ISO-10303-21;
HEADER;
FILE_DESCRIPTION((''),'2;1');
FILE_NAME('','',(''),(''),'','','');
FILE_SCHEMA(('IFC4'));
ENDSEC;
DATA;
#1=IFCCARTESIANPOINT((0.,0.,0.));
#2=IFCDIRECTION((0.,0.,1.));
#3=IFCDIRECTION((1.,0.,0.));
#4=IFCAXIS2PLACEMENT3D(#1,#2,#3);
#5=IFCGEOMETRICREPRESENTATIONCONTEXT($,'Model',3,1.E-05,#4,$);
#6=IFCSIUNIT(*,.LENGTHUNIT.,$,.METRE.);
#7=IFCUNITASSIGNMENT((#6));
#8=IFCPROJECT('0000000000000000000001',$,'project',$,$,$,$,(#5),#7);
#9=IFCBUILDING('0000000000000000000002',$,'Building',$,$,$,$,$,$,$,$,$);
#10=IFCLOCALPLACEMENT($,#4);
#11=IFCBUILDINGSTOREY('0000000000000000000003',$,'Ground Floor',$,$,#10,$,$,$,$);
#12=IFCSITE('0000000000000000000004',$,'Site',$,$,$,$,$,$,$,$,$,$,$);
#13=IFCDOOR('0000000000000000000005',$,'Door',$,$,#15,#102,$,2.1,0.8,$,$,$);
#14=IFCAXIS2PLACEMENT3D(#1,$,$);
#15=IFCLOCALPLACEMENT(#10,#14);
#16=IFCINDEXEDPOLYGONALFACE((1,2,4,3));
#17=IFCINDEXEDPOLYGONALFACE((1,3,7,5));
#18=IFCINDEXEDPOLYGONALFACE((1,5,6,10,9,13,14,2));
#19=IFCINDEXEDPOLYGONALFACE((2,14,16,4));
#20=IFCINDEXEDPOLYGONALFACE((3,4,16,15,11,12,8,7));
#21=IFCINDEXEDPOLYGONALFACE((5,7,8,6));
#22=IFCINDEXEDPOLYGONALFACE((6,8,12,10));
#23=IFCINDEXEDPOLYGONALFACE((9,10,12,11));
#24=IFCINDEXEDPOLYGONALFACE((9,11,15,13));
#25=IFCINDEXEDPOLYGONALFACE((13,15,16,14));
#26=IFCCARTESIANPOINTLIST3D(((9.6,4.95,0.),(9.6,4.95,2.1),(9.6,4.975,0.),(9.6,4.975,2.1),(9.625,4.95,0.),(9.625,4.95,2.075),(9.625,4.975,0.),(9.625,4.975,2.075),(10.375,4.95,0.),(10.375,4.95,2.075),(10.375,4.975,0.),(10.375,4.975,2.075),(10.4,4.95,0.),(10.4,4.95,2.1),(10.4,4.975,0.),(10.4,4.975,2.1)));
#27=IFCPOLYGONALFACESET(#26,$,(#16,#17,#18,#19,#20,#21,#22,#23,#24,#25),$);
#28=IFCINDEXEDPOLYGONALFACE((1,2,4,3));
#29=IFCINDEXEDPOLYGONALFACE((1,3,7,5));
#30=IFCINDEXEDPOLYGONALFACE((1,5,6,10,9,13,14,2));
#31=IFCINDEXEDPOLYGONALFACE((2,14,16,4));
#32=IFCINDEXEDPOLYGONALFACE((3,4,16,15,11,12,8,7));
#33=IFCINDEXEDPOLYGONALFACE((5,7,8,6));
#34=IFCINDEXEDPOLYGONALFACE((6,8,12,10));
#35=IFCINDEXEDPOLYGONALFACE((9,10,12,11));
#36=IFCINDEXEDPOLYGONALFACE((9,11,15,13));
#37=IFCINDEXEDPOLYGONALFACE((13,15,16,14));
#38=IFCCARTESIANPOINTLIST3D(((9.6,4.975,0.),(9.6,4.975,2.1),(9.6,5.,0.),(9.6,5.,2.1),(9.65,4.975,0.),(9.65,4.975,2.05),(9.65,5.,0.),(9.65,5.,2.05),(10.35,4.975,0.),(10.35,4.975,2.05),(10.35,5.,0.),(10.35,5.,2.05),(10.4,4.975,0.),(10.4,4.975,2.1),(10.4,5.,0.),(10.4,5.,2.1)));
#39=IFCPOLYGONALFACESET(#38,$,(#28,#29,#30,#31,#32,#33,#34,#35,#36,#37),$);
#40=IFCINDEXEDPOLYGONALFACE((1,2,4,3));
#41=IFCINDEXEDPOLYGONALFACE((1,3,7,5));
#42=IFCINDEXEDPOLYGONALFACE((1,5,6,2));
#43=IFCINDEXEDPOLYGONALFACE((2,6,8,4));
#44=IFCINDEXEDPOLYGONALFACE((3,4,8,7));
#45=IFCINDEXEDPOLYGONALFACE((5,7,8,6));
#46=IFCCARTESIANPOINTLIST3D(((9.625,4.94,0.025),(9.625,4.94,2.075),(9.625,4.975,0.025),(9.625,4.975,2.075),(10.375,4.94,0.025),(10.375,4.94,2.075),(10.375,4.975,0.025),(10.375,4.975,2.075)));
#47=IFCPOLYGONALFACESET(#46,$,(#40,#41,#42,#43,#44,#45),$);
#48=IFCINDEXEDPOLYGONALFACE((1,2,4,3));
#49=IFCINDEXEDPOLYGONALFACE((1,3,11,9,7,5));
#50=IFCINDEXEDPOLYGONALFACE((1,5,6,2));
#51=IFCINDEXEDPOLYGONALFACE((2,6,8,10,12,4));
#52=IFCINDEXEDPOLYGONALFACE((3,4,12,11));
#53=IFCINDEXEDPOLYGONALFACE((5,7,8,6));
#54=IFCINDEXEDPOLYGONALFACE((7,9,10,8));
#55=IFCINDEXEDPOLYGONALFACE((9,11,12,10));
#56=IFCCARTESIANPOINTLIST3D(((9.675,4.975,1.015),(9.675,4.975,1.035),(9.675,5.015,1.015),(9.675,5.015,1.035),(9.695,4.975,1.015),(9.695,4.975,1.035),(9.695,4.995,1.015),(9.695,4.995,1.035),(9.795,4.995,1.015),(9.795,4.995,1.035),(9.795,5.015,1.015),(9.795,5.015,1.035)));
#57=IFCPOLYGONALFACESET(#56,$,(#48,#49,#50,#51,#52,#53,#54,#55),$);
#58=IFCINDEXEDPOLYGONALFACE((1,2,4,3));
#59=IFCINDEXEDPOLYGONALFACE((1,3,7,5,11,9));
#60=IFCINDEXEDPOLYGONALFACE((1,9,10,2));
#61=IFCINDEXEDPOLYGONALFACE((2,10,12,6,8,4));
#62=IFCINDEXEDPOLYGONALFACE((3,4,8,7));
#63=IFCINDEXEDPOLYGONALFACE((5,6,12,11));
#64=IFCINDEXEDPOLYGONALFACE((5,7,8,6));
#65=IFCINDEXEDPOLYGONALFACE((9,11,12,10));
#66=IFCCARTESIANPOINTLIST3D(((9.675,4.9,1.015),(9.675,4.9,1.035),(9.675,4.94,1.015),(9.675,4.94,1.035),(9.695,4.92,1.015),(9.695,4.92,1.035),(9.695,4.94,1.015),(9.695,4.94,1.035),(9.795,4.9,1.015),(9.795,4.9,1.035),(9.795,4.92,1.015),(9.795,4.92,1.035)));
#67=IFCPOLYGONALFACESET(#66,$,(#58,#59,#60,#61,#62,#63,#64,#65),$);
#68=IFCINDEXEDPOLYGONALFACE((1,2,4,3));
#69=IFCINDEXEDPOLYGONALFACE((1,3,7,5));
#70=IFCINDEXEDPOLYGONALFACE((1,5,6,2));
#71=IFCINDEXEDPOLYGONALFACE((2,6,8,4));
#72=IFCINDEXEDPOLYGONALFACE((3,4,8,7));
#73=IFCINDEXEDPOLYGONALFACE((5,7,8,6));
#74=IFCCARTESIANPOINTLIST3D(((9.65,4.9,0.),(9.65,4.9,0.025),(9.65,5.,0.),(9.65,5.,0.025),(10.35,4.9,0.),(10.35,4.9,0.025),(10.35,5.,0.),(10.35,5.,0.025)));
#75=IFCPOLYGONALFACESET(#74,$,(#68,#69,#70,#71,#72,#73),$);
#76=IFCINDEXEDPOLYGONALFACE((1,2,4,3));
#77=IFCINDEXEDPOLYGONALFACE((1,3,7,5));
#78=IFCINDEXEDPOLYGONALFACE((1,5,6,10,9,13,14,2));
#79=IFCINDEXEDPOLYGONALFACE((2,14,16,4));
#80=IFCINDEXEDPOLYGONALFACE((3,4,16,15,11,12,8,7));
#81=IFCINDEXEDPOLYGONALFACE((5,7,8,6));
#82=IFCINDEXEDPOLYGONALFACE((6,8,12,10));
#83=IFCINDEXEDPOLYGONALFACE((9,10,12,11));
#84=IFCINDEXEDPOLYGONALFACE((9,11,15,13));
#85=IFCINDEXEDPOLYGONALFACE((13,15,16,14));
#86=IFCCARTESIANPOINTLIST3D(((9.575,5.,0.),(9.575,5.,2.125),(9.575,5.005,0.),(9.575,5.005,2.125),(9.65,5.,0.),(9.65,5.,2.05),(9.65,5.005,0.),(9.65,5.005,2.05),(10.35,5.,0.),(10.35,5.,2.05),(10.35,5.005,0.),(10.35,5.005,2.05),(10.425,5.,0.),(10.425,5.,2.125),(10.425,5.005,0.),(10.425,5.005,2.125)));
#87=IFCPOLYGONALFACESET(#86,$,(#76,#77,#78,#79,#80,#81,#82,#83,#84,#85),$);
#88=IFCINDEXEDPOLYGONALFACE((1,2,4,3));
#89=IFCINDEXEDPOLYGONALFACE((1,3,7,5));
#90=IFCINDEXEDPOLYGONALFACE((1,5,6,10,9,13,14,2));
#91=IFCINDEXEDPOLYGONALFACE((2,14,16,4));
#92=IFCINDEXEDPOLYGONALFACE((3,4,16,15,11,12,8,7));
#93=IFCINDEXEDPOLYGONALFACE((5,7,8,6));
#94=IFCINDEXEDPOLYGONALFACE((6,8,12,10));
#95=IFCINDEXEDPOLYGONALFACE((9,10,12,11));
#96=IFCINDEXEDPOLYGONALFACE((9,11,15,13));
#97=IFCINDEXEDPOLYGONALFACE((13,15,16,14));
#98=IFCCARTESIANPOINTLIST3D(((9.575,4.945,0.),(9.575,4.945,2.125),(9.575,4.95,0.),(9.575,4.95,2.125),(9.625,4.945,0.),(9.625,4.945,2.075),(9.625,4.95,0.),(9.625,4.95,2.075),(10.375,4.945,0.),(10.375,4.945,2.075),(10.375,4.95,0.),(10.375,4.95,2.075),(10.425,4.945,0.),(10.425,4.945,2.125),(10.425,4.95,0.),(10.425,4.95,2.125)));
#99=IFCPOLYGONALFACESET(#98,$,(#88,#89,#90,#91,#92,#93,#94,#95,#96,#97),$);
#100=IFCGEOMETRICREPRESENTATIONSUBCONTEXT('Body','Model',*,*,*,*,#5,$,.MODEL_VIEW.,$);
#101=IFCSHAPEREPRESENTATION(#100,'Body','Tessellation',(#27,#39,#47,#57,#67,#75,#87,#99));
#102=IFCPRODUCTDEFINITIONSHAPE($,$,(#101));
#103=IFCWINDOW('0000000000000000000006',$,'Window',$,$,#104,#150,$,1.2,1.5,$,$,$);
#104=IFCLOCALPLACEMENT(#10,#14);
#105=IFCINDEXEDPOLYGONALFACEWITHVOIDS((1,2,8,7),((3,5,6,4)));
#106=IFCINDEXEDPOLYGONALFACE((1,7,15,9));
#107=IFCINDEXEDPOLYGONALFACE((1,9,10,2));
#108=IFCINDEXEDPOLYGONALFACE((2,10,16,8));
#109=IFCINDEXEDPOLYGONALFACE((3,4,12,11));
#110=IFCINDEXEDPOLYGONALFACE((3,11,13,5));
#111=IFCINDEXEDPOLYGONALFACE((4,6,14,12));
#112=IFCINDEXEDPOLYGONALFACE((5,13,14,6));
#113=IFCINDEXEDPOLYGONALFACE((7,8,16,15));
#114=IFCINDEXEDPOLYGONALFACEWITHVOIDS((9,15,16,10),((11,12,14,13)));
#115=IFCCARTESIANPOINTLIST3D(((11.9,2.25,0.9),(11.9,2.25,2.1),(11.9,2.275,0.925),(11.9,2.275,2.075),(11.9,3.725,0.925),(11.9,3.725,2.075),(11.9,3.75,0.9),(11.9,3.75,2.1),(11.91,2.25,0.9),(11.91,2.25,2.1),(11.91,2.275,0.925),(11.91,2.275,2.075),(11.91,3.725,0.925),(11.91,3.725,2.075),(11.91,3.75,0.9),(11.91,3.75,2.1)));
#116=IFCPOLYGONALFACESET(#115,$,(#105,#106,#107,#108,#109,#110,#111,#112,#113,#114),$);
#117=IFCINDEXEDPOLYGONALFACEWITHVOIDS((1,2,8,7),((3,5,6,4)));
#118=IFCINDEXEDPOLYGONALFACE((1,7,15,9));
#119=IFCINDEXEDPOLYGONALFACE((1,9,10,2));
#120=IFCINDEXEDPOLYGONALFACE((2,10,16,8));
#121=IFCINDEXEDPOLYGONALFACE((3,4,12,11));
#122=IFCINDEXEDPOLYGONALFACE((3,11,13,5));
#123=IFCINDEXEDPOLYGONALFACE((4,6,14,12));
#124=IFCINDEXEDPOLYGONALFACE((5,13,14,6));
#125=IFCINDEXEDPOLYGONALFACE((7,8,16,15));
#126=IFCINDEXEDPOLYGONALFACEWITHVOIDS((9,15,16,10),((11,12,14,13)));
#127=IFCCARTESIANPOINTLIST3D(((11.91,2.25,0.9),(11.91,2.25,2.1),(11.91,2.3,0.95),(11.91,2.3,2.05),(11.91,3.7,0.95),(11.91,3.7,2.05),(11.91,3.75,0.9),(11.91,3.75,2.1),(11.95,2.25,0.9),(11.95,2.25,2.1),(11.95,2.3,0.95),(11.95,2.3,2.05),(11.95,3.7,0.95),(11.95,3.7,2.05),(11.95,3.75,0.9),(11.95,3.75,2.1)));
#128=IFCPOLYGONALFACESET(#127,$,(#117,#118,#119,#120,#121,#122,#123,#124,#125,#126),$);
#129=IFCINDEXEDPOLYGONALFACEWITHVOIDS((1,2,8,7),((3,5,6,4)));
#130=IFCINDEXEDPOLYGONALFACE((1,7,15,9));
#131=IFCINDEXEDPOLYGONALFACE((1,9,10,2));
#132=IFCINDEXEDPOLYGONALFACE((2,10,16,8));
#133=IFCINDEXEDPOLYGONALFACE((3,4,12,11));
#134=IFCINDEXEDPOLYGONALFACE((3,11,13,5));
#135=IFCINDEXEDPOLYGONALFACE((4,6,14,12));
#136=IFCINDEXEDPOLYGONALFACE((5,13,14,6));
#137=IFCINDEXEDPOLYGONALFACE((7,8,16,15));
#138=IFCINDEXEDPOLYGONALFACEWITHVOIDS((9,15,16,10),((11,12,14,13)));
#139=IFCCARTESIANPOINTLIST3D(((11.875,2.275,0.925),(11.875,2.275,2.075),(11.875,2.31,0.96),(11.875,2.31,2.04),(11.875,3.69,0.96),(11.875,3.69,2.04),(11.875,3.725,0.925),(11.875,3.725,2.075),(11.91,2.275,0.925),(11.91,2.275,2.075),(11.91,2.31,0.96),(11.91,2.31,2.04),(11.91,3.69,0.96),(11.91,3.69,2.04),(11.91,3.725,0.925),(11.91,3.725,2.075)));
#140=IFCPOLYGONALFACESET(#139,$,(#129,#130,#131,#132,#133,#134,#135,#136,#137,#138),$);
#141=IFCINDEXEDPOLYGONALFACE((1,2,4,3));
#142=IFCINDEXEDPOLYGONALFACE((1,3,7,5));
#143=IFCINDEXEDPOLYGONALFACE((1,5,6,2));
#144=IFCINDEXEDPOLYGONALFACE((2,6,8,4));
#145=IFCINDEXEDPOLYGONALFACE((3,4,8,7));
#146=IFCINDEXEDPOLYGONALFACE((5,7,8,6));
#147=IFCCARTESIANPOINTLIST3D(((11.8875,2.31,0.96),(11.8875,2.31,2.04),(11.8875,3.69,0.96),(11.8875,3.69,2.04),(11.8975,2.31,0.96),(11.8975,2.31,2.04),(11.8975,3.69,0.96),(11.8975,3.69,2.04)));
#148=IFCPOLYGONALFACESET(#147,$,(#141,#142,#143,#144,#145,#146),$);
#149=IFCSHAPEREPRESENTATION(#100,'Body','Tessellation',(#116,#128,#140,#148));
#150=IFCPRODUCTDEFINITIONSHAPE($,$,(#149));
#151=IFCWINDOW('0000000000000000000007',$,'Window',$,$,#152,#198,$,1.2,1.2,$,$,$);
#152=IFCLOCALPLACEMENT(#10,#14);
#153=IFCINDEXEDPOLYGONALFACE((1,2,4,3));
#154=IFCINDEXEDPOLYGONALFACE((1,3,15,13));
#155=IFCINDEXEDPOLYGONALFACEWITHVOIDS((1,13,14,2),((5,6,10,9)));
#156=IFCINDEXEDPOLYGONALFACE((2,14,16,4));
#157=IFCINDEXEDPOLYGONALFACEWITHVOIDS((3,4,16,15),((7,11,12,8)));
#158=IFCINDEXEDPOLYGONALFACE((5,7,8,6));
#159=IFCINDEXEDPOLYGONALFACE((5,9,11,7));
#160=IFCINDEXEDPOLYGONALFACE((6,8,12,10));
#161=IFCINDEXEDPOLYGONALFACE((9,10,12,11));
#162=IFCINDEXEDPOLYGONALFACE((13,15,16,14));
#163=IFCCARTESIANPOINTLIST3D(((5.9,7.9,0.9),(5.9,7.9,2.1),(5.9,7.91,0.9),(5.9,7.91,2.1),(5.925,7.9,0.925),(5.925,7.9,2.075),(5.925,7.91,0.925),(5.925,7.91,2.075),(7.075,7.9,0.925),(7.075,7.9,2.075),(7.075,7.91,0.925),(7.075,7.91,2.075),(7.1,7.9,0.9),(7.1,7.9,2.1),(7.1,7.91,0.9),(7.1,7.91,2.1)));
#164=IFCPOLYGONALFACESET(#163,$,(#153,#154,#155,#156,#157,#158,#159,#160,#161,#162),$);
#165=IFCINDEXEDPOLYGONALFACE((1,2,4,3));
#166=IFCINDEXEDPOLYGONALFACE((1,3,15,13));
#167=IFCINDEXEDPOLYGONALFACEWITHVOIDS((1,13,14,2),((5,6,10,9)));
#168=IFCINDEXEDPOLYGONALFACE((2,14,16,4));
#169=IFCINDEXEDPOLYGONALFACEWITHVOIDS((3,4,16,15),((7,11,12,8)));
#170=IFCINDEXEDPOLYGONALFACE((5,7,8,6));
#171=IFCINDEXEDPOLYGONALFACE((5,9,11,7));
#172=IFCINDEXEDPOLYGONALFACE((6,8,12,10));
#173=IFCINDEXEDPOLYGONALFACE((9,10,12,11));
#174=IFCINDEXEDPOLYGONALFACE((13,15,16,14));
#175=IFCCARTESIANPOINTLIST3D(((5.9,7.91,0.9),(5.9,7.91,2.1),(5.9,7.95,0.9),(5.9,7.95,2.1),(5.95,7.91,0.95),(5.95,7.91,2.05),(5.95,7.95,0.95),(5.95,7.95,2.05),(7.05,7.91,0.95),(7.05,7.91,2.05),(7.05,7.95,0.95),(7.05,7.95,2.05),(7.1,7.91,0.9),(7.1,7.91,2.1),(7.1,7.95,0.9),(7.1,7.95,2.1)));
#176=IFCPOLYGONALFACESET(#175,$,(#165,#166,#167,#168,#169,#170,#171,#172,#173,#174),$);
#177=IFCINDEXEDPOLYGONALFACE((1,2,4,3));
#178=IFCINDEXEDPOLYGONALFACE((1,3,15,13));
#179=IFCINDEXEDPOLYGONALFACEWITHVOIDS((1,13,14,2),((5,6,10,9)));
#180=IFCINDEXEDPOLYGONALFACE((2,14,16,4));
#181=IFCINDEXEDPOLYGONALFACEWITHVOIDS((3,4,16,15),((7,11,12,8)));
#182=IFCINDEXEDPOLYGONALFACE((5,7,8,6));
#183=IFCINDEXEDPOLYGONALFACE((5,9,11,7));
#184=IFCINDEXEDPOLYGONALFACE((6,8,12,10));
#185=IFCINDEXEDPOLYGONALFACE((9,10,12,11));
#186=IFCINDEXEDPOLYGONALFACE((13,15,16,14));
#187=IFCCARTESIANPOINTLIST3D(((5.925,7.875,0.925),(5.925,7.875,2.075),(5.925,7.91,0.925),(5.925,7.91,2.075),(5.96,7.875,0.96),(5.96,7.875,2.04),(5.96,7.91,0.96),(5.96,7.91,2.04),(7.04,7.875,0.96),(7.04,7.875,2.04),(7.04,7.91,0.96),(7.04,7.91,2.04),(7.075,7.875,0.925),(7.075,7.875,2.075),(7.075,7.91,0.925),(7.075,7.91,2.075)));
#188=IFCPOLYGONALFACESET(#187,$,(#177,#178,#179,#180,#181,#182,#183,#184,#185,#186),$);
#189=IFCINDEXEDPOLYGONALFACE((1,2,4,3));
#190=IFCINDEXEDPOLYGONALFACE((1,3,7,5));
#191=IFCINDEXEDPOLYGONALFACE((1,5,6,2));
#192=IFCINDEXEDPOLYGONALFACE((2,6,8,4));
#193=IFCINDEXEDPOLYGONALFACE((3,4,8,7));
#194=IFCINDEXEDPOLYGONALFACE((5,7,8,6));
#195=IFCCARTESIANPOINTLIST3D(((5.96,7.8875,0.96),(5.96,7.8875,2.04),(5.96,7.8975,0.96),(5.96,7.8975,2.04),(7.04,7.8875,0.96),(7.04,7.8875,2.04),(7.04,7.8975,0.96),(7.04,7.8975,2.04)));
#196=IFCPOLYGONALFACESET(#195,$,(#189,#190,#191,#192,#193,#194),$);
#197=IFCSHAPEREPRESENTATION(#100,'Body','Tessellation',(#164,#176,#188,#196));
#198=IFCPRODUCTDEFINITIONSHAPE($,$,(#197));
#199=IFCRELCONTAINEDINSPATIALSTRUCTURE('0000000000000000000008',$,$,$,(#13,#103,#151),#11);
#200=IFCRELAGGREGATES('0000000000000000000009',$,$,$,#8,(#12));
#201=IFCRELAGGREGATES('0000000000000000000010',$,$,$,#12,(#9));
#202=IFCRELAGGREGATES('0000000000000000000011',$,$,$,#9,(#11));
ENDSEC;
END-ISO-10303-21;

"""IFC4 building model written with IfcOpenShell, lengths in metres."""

from ifc_helpers import new_model, si_unit, frame, origin_with_axes, place, context, subcontext, project, spatial, line, indexed_curve, outline, extrude, element, save


model = new_model("IFC4")

# Units and contexts
model_context = context("Model", 3, precision=1e-05, world=origin_with_axes())
body_context = subcontext(model_context, "Body", "Model", "MODEL_VIEW")
ifc_project = project(units=[si_unit("LENGTHUNIT", "METRE")], contexts=[model_context])

# Site, building, storey
site = spatial("IfcSite", under=ifc_project, Name="Site")
building = spatial("IfcBuilding", under=site, Name="Building")
storey_placement = place(None, origin_with_axes())
storey = spatial("IfcBuildingStorey", under=building, at=storey_placement, Name="Ground Floor")

# Door
door_1_placement = place(storey_placement, frame((10.4, 5.0, 0.0), z_axis=(0.0, 0.0, 1.0), x_axis=(-1.0, 0.0, 0.0)))
element("IfcDoor", 1, at=door_1_placement, inside=storey, Name="Door", OverallHeight=2.1, OverallWidth=0.8, context=body_context, shape_type="SweptSolid", body=[
    extrude(outline(indexed_curve([(0.0, 0.0), (0.0, 2.1), (0.8, 2.1), (0.8, 0.0), (0.775, 0.0), (0.775, 2.075), (0.025, 2.075), (0.025, 0.0)], segments=[line(1, 2, 3, 4, 5, 6, 7, 8, 1)])), frame((0.0, 0.025, 0.0), z_axis=(0.0, -1.0, 0.0), x_axis=(1.0, 0.0, 0.0)), (0.0, 0.0, -1.0), 0.025),
    extrude(outline(indexed_curve([(0.0, 0.0), (0.0, 2.1), (0.8, 2.1), (0.8, 0.0), (0.75, 0.0), (0.75, 2.05), (0.05, 2.05), (0.05, 0.0)], segments=[line(1, 2, 3, 4, 5, 6, 7, 8, 1)])), frame((0.0, 0.0, 0.0), z_axis=(0.0, -1.0, 0.0), x_axis=(1.0, 0.0, 0.0)), (0.0, 0.0, -1.0), 0.025),
    extrude(outline(indexed_curve([(0.0, 0.0), (0.75, 0.0), (0.75, 0.035), (0.0, 0.035)], segments=[line(1, 2, 3, 4, 1)])), frame((0.025, 0.025, 0.025), z_axis=(0.0, 0.0, 1.0), x_axis=(1.0, 0.0, 0.0)), (0.0, 0.0, 1.0), 2.05),
    extrude(outline(indexed_curve([(0.0, 0.0), (0.0, -0.04), (-0.12, -0.04), (-0.12, -0.02), (-0.02, -0.02), (-0.02, 0.0)], segments=[line(1, 2, 3, 4, 5, 6, 1)])), frame((0.725, 0.025, 1.015), z_axis=(0.0, 0.0, 1.0), x_axis=(1.0, 0.0, 0.0)), (0.0, 0.0, 1.0), 0.02),
    extrude(outline(indexed_curve([(0.0, 0.0), (0.0, 0.04), (-0.12, 0.04), (-0.12, 0.02), (-0.02, 0.02), (-0.02, 0.0)], segments=[line(1, 2, 3, 4, 5, 6, 1)])), frame((0.725, 0.06, 1.015), z_axis=(0.0, 0.0, 1.0), x_axis=(1.0, 0.0, 0.0)), (0.0, 0.0, 1.0), 0.02),
    extrude(outline(indexed_curve([(0.0, 0.0), (0.7, 0.0), (0.7, 0.1), (0.0, 0.1)], segments=[line(1, 2, 3, 4, 1)])), frame((0.05, 0.0, 0.0), z_axis=(0.0, 0.0, 1.0), x_axis=(1.0, 0.0, 0.0)), (0.0, 0.0, 1.0), 0.025),
    extrude(outline(indexed_curve([(0.0, 0.0), (0.0, 2.125), (0.85, 2.125), (0.85, 0.0), (0.775, 0.0), (0.775, 2.05), (0.075, 2.05), (0.075, 0.0)], segments=[line(1, 2, 3, 4, 5, 6, 7, 8, 1)])), frame((-0.025, -0.005, 0.0), z_axis=(0.0, -1.0, 0.0), x_axis=(1.0, 0.0, 0.0)), (0.0, 0.0, -1.0), 0.005),
    extrude(outline(indexed_curve([(0.0, 0.0), (0.0, 2.125), (0.85, 2.125), (0.85, 0.0), (0.8, 0.0), (0.8, 2.075), (0.05, 2.075), (0.05, 0.0)], segments=[line(1, 2, 3, 4, 5, 6, 7, 8, 1)])), frame((-0.025, 0.05, 0.0), z_axis=(0.0, -1.0, 0.0), x_axis=(1.0, 0.0, 0.0)), (0.0, 0.0, -1.0), 0.005),
])

# Windows
window_1_placement = place(storey_placement, frame((12.0, 2.25, 0.9), z_axis=(0.0, 0.0, 1.0), x_axis=(0.0, 1.0, 0.0)))
element("IfcWindow", 2, at=window_1_placement, inside=storey, Name="Window", OverallHeight=1.2, OverallWidth=1.5, context=body_context, shape_type="SweptSolid", body=[
    extrude(outline(indexed_curve([(0.0, 0.0), (1.5, 0.0), (1.5, 1.2), (0.0, 1.2)], segments=[line(1, 2, 3, 4, 1)]), holes=[indexed_curve([(0.025, 0.025), (1.475, 0.025), (1.475, 1.175), (0.025, 1.175)], segments=[line(1, 2, 3, 4, 1)])]), frame((0.0, 0.09, 0.0), z_axis=(0.0, -1.0, 0.0), x_axis=(1.0, 0.0, 0.0)), (0.0, 0.0, -1.0), 0.01),
    extrude(outline(indexed_curve([(0.0, 0.0), (1.5, 0.0), (1.5, 1.2), (0.0, 1.2)], segments=[line(1, 2, 3, 4, 1)]), holes=[indexed_curve([(0.05, 0.05), (1.45, 0.05), (1.45, 1.15), (0.05, 1.15)], segments=[line(1, 2, 3, 4, 1)])]), frame((0.0, 0.05, 0.0), z_axis=(0.0, -1.0, 0.0), x_axis=(1.0, 0.0, 0.0)), (0.0, 0.0, -1.0), 0.04),
    extrude(outline(indexed_curve([(0.0, 0.0), (1.45, 0.0), (1.45, 1.15), (0.0, 1.15)], segments=[line(1, 2, 3, 4, 1)]), holes=[indexed_curve([(0.035, 0.035), (1.415, 0.035), (1.415, 1.115), (0.035, 1.115)], segments=[line(1, 2, 3, 4, 1)])]), frame((0.025, 0.09, 0.025), z_axis=(0.0, -1.0, 0.0), x_axis=(1.0, 0.0, 0.0)), (0.0, 0.0, -1.0), 0.035),
    extrude(outline(indexed_curve([(0.035, 0.035), (1.415, 0.035), (1.415, 1.115), (0.035, 1.115)], segments=[line(1, 2, 3, 4, 1)])), frame((0.025, 0.1025, 0.025), z_axis=(0.0, -1.0, 0.0), x_axis=(1.0, 0.0, 0.0)), (0.0, 0.0, -1.0), 0.01),
])
window_2_placement = place(storey_placement, frame((7.1, 8.0, 0.9), z_axis=(0.0, 0.0, 1.0), x_axis=(-1.0, 0.0, 0.0)))
element("IfcWindow", 3, at=window_2_placement, inside=storey, Name="Window", OverallHeight=1.2, OverallWidth=1.2, context=body_context, shape_type="SweptSolid", body=[
    extrude(outline(indexed_curve([(0.0, 0.0), (1.2, 0.0), (1.2, 1.2), (0.0, 1.2)], segments=[line(1, 2, 3, 4, 1)]), holes=[indexed_curve([(0.025, 0.025), (1.175, 0.025), (1.175, 1.175), (0.025, 1.175)], segments=[line(1, 2, 3, 4, 1)])]), frame((0.0, 0.09, 0.0), z_axis=(0.0, -1.0, 0.0), x_axis=(1.0, 0.0, 0.0)), (0.0, 0.0, -1.0), 0.01),
    extrude(outline(indexed_curve([(0.0, 0.0), (1.2, 0.0), (1.2, 1.2), (0.0, 1.2)], segments=[line(1, 2, 3, 4, 1)]), holes=[indexed_curve([(0.05, 0.05), (1.15, 0.05), (1.15, 1.15), (0.05, 1.15)], segments=[line(1, 2, 3, 4, 1)])]), frame((0.0, 0.05, 0.0), z_axis=(0.0, -1.0, 0.0), x_axis=(1.0, 0.0, 0.0)), (0.0, 0.0, -1.0), 0.04),
    extrude(outline(indexed_curve([(0.0, 0.0), (1.15, 0.0), (1.15, 1.15), (0.0, 1.15)], segments=[line(1, 2, 3, 4, 1)]), holes=[indexed_curve([(0.035, 0.035), (1.115, 0.035), (1.115, 1.115), (0.035, 1.115)], segments=[line(1, 2, 3, 4, 1)])]), frame((0.025, 0.09, 0.025), z_axis=(0.0, -1.0, 0.0), x_axis=(1.0, 0.0, 0.0)), (0.0, 0.0, -1.0), 0.035),
    extrude(outline(indexed_curve([(0.035, 0.035), (1.115, 0.035), (1.115, 1.115), (0.035, 1.115)], segments=[line(1, 2, 3, 4, 1)])), frame((0.025, 0.1025, 0.025), z_axis=(0.0, -1.0, 0.0), x_axis=(1.0, 0.0, 0.0)), (0.0, 0.0, -1.0), 0.01),
])

save(model, "model.ifc")
